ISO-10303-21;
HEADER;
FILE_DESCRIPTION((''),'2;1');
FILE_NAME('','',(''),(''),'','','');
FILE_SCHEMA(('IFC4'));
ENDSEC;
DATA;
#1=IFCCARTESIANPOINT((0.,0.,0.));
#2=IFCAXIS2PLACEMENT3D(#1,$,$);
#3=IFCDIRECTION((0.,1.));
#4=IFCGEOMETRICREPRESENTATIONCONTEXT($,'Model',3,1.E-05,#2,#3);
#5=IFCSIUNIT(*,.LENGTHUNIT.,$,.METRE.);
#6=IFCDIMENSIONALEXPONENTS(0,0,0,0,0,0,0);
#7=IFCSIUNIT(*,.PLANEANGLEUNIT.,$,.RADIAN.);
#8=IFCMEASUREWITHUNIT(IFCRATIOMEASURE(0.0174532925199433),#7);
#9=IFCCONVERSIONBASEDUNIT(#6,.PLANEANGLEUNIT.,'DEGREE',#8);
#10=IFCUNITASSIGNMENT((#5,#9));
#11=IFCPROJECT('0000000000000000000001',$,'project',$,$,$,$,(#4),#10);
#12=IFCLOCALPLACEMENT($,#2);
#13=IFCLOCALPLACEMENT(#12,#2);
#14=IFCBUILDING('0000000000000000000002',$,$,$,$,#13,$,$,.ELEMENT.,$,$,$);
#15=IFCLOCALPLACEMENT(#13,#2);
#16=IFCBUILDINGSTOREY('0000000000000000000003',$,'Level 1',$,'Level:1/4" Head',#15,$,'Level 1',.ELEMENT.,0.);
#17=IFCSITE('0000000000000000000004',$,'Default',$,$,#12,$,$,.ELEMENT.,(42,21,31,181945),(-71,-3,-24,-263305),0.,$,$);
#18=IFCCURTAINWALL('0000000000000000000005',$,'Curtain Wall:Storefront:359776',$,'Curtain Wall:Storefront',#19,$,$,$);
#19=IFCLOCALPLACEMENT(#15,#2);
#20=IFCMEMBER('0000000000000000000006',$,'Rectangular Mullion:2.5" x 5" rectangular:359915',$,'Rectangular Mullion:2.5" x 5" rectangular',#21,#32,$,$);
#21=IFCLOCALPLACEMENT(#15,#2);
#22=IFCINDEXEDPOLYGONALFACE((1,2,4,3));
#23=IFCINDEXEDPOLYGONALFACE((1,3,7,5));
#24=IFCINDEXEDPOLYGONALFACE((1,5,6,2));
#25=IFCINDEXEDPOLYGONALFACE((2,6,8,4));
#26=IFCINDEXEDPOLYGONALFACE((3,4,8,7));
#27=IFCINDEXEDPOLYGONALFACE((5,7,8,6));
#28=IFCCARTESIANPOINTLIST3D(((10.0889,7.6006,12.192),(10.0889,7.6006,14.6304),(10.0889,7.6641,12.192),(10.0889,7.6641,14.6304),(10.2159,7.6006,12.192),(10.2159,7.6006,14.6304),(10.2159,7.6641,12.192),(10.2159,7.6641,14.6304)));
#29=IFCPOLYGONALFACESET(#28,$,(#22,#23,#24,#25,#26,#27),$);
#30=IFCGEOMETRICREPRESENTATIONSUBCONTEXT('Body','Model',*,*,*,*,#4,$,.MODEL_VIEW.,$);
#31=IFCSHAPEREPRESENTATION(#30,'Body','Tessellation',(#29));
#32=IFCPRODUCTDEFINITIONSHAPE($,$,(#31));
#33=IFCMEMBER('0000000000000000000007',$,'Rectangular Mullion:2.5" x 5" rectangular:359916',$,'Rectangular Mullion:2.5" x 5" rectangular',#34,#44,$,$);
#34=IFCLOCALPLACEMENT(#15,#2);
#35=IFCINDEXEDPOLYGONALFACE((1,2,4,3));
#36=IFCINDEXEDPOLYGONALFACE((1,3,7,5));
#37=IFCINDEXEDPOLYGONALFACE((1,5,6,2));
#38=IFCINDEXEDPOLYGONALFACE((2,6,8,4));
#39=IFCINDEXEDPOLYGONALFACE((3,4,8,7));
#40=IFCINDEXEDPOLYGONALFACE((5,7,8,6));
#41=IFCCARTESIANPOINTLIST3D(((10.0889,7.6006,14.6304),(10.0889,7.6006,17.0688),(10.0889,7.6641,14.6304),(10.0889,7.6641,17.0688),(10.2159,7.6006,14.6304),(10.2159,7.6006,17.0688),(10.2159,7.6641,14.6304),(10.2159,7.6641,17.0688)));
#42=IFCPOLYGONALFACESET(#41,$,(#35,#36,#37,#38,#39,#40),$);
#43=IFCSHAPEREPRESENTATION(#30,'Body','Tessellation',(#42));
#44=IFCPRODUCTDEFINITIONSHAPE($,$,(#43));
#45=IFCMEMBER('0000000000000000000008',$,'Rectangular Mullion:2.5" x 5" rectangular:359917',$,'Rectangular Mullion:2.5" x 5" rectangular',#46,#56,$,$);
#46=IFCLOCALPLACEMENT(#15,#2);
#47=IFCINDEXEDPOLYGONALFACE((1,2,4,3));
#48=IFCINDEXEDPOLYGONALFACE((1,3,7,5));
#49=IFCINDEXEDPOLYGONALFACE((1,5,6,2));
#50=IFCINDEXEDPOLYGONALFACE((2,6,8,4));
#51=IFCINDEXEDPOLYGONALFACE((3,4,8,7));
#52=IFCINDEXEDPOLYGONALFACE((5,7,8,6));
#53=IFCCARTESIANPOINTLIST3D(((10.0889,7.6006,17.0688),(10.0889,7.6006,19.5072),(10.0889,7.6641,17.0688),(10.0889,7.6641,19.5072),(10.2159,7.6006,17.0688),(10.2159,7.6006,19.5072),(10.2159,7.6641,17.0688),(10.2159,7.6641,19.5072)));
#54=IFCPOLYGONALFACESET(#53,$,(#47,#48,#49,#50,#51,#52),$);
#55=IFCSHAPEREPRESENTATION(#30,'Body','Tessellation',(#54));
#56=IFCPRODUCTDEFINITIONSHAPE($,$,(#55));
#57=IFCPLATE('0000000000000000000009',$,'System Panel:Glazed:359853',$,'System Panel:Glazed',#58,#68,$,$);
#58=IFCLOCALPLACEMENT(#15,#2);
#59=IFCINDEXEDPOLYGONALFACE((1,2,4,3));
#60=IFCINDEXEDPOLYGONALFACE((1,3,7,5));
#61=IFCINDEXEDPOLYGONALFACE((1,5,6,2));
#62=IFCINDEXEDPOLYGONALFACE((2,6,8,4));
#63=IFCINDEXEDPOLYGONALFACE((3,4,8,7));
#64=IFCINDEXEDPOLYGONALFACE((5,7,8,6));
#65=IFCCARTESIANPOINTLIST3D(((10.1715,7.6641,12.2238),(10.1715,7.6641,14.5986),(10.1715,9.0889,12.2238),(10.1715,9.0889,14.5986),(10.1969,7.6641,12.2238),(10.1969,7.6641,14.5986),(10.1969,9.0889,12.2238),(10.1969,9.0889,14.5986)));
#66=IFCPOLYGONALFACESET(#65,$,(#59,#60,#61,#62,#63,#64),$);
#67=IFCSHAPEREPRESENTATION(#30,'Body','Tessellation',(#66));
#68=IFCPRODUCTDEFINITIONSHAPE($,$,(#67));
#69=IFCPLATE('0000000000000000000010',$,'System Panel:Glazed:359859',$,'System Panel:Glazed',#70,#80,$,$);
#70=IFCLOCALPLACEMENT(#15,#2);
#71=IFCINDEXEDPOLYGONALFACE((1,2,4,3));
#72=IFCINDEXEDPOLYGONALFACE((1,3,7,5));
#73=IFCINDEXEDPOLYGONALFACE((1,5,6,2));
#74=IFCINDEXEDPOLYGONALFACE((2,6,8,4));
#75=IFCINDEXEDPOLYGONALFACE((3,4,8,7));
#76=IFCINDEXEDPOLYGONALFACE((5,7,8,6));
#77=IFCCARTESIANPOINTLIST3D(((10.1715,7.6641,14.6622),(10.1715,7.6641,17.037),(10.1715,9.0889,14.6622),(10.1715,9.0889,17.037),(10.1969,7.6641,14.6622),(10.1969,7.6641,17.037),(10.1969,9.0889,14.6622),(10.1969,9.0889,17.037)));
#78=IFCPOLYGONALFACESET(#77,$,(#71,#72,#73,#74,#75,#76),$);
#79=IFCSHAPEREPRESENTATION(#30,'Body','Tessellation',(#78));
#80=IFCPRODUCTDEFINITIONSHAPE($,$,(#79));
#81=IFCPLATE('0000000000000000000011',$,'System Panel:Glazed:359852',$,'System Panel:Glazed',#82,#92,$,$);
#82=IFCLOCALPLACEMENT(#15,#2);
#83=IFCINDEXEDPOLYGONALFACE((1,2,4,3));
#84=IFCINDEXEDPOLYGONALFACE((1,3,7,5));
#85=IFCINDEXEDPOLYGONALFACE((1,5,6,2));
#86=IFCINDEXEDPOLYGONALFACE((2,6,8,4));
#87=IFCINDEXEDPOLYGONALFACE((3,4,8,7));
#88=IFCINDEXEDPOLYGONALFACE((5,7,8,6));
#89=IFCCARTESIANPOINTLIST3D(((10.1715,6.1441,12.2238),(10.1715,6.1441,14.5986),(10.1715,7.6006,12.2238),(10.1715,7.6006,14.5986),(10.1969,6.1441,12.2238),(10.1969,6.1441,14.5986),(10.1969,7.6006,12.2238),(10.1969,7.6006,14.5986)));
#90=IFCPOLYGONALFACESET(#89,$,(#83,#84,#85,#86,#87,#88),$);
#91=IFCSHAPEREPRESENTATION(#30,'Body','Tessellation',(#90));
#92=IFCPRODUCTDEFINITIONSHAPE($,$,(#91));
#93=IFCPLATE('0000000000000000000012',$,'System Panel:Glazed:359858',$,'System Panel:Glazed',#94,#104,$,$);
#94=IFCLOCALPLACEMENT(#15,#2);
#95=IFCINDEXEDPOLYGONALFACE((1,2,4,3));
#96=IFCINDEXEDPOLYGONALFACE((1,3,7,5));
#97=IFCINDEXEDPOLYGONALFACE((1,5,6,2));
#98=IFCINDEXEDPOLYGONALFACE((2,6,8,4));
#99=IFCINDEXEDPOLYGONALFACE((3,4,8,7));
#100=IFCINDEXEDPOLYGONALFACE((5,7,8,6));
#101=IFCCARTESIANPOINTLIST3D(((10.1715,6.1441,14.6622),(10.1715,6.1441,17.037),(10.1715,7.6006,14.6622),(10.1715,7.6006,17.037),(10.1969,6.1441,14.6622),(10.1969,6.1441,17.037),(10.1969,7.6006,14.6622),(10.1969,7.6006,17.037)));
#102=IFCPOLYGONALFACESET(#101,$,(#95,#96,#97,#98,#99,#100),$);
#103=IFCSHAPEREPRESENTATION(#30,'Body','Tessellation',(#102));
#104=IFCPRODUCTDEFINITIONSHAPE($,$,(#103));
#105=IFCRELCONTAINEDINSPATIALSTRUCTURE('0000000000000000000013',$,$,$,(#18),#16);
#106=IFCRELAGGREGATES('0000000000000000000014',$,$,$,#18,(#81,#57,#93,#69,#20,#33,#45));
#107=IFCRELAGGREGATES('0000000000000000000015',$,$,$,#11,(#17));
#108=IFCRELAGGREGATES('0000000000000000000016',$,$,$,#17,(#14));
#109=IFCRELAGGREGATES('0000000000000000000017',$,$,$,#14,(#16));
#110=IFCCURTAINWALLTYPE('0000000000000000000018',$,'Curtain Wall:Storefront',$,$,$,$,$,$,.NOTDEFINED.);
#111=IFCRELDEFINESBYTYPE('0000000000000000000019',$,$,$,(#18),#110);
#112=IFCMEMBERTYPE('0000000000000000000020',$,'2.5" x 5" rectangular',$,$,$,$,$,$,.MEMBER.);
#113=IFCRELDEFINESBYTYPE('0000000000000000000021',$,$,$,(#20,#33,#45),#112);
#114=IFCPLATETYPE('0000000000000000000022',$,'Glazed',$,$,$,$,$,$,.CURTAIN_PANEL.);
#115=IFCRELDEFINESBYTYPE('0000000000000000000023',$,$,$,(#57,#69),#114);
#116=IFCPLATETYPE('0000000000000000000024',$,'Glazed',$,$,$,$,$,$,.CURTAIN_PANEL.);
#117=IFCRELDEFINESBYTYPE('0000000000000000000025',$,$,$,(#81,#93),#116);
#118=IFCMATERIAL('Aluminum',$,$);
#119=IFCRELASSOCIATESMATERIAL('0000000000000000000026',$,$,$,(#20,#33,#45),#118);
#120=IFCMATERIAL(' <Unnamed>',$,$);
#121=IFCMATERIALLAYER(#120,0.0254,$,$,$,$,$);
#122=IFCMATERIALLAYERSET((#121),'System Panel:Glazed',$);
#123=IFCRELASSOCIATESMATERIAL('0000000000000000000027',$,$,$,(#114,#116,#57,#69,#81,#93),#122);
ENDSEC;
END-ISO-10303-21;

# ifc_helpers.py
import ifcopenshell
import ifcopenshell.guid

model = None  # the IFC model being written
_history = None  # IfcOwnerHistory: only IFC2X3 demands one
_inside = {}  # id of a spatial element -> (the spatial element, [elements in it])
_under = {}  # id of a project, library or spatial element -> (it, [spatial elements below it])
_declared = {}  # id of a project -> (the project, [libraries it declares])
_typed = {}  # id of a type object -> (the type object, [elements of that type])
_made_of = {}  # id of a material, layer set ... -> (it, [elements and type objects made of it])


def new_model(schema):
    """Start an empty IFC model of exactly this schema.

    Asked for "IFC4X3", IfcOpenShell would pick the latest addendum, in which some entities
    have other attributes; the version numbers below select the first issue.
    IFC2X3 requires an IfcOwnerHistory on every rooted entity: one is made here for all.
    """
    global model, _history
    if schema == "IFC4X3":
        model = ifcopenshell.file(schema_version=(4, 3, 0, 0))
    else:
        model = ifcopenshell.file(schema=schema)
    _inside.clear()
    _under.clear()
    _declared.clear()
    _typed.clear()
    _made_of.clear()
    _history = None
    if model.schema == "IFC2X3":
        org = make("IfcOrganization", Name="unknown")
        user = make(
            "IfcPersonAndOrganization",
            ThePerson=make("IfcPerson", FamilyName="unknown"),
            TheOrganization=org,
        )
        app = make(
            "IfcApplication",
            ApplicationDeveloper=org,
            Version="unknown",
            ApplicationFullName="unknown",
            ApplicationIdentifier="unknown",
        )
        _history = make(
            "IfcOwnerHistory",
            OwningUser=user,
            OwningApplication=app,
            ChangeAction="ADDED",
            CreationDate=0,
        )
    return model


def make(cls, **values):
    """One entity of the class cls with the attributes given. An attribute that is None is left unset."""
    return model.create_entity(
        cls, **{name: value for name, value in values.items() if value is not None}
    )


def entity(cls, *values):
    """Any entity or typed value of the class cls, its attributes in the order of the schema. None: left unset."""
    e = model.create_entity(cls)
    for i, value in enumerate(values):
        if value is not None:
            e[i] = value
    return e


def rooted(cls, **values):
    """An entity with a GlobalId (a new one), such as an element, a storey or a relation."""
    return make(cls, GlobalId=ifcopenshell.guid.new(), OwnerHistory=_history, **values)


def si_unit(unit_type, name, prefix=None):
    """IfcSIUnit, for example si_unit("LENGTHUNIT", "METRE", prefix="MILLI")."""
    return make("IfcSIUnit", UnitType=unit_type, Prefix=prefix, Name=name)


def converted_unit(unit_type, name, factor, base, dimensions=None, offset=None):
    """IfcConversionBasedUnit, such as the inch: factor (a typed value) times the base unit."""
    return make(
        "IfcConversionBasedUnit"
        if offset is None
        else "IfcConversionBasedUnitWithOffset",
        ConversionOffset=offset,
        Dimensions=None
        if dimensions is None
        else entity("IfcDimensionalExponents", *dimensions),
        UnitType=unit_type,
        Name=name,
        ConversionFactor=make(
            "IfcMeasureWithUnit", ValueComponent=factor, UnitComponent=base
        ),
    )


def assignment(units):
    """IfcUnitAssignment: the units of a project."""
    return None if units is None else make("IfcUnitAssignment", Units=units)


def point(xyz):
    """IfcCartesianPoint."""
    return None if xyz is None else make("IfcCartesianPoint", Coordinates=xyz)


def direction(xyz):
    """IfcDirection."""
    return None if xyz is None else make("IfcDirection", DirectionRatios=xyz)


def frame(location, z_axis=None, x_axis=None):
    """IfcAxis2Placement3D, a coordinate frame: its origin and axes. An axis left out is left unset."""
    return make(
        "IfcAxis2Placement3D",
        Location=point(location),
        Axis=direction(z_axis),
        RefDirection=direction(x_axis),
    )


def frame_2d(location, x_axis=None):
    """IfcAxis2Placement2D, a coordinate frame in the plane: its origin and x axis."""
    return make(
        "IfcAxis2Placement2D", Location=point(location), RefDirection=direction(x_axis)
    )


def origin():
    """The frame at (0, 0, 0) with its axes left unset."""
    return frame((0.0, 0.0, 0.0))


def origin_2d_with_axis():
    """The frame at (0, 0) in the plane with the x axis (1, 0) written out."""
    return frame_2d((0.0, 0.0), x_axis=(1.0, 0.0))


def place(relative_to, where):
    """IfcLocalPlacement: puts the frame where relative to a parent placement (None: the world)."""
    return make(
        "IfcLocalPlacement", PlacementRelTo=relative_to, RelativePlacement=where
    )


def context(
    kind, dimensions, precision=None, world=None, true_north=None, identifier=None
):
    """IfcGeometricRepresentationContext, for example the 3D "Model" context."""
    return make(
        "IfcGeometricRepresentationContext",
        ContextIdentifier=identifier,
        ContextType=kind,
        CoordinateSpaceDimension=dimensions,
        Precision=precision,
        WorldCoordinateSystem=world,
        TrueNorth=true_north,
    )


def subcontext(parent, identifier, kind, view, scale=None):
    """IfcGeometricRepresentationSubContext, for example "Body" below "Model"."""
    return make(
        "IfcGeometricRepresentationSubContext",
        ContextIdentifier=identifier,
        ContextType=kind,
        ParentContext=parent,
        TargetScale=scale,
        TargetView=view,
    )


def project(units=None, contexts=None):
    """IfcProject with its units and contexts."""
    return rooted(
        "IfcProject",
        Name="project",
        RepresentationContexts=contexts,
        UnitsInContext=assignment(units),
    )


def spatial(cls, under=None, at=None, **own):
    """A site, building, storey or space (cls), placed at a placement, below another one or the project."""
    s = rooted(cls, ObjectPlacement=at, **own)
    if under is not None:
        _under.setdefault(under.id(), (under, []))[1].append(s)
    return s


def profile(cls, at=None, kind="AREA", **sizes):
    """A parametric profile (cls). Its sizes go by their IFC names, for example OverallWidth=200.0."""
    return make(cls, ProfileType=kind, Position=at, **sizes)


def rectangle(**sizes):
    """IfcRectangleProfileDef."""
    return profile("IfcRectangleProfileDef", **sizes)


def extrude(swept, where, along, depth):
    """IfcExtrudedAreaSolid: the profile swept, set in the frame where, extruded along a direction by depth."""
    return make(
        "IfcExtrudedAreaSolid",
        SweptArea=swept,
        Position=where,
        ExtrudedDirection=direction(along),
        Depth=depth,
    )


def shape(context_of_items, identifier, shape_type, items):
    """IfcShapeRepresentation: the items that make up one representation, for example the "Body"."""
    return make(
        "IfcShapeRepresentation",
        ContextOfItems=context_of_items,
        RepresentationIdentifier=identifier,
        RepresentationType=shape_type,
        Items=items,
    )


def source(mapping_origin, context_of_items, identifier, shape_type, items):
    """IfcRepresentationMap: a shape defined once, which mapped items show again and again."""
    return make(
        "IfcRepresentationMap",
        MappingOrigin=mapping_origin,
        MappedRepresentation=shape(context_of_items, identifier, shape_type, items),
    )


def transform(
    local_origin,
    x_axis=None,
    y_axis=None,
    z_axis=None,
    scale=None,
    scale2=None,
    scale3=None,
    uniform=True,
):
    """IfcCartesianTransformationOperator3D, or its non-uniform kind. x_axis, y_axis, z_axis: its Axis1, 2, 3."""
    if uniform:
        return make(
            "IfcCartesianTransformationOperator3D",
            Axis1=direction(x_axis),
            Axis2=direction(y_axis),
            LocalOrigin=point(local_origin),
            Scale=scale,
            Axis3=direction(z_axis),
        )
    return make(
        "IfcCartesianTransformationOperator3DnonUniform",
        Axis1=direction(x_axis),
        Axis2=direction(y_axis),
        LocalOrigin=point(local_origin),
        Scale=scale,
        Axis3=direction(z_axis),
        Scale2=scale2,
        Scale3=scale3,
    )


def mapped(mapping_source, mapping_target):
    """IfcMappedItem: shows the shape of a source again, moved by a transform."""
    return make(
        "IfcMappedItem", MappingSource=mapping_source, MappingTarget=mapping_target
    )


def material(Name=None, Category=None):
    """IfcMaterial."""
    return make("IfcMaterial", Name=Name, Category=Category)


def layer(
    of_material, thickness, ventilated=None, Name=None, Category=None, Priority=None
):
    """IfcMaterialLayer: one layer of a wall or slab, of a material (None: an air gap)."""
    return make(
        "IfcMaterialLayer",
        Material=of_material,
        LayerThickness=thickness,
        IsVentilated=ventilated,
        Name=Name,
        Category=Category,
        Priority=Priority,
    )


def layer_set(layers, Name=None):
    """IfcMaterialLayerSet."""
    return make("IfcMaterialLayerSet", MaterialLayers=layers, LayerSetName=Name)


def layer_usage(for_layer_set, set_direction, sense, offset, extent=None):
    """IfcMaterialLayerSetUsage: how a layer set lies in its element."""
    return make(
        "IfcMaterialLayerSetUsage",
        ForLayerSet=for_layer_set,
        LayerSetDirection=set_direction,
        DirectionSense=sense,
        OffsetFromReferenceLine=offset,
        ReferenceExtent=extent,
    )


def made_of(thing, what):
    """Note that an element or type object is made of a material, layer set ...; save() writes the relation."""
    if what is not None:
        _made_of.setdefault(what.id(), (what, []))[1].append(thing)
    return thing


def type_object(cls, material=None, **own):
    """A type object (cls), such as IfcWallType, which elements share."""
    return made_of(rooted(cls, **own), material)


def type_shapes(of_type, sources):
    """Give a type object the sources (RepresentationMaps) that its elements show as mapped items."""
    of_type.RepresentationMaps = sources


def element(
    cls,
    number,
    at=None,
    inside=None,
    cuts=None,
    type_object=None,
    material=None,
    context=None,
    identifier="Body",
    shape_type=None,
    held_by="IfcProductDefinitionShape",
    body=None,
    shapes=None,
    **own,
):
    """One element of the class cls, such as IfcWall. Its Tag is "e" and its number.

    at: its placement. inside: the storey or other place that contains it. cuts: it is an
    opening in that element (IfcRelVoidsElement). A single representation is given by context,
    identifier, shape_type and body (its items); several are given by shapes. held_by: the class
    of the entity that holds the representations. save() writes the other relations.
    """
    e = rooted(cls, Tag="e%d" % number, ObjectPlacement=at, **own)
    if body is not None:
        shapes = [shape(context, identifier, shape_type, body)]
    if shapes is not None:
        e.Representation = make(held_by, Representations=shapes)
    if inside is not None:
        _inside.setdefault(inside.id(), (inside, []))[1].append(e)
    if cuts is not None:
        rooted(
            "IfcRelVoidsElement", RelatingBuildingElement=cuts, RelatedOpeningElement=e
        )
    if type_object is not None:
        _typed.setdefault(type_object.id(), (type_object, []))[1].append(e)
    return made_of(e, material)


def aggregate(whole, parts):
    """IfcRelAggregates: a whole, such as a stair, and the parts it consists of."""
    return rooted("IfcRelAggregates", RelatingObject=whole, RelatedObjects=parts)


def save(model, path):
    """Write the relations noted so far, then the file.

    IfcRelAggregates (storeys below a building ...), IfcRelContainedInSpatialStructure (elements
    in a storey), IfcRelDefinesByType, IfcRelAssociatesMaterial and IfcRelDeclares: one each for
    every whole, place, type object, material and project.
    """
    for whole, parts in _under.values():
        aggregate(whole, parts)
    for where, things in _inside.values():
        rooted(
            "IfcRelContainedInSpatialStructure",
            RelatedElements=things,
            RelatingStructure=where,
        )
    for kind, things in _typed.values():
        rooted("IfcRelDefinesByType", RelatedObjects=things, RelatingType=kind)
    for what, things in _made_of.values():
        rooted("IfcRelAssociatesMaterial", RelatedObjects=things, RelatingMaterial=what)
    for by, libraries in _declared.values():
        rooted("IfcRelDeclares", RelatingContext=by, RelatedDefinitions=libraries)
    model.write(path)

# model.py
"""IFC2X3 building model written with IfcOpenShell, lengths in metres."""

from ifc_helpers import new_model, entity, si_unit, converted_unit, direction, frame, frame_2d, origin, origin_2d_with_axis, place, context, subcontext, project, spatial, rectangle, extrude, source, transform, mapped, material, layer, layer_set, layer_usage, type_object, type_shapes, element, aggregate, save


model = new_model("IFC2X3")

# Units and contexts
model_context = context("Model", 3, precision=1e-05, world=origin(), true_north=direction((0.0, 1.0)))
body_context = subcontext(model_context, "Body", "Model", "MODEL_VIEW")
ifc_project = project(units=[si_unit("LENGTHUNIT", "METRE"), converted_unit("PLANEANGLEUNIT", "DEGREE", entity("IfcRatioMeasure", 0.0174532925199433), si_unit("PLANEANGLEUNIT", "RADIAN"), dimensions=[0, 0, 0, 0, 0, 0, 0])], contexts=[model_context])

# Site, building, storey
site_placement = place(None, origin())
site = spatial("IfcSite", under=ifc_project, at=site_placement, Name="Default", CompositionType="ELEMENT", RefLatitude=(42, 21, 31, 181945), RefLongitude=(-71, -3, -24, -263305), RefElevation=0.0)
building_placement = place(site_placement, origin())
building = spatial("IfcBuilding", under=site, at=building_placement, CompositionType="ELEMENT")
storey_placement = place(building_placement, origin())
storey = spatial("IfcBuildingStorey", under=building, at=storey_placement, Name="Level 1", ObjectType="Level:1/4\" Head", LongName="Level 1", CompositionType="ELEMENT", Elevation=0.0)

# Curtain wall, members, plates
curtain_wall_type = type_object("IfcCurtainWallType", Name="Curtain Wall:Storefront", PredefinedType="NOTDEFINED")
curtain_wall_placement = place(storey_placement, origin())
curtain_wall = element("IfcCurtainWall", 1, at=curtain_wall_placement, inside=storey, type_object=curtain_wall_type, Name="Curtain Wall:Storefront:359776", ObjectType="Curtain Wall:Storefront")
ifc_material_1 = material(Name="Aluminum")
member_type_1 = type_object("IfcMemberType", Name="2.5\" x 5\" rectangular", PredefinedType="MEMBER")
shared_shape_1 = source(origin(), body_context, "Body", "SweptSolid", [
    extrude(rectangle(XDim=0.127, YDim=0.0635, at=origin_2d_with_axis()), frame((0.0, 0.0, -2.4384), z_axis=(0.0, 0.0, 1.0), x_axis=(0.0, -1.0, 0.0)), (0.0, 0.0, 1.0), 2.4384),
])
type_shapes(member_type_1, [shared_shape_1])
member_1_placement = place(storey_placement, frame((10.1524, 7.6324, 12.192), z_axis=(0.0, 0.0, -1.0), x_axis=(0.0, 1.0, 0.0)))
member_1 = element("IfcMember", 2, at=member_1_placement, type_object=member_type_1, material=ifc_material_1, Name="Rectangular Mullion:2.5\" x 5\" rectangular:359915", ObjectType="Rectangular Mullion:2.5\" x 5\" rectangular", context=body_context, shape_type="MappedRepresentation", body=[
    mapped(shared_shape_1, transform((0.0, 0.0, 0.0), scale=1.0)),
])
member_2_placement = place(storey_placement, frame((10.1524, 7.6324, 14.6304), z_axis=(0.0, 0.0, -1.0), x_axis=(0.0, 1.0, 0.0)))
member_2 = element("IfcMember", 3, at=member_2_placement, type_object=member_type_1, material=ifc_material_1, Name="Rectangular Mullion:2.5\" x 5\" rectangular:359916", ObjectType="Rectangular Mullion:2.5\" x 5\" rectangular", context=body_context, shape_type="MappedRepresentation", body=[
    mapped(shared_shape_1, transform((0.0, 0.0, 0.0), scale=1.0)),
])
member_3_placement = place(storey_placement, frame((10.1524, 7.6324, 17.0688), z_axis=(0.0, 0.0, -1.0), x_axis=(0.0, 1.0, 0.0)))
member_3 = element("IfcMember", 4, at=member_3_placement, type_object=member_type_1, material=ifc_material_1, Name="Rectangular Mullion:2.5\" x 5\" rectangular:359917", ObjectType="Rectangular Mullion:2.5\" x 5\" rectangular", context=body_context, shape_type="MappedRepresentation", body=[
    mapped(shared_shape_1, transform((0.0, 0.0, 0.0), scale=1.0)),
])
ifc_material_2 = material(Name=" <Unnamed>")
ifc_layer = layer(ifc_material_2, 0.0254)
ifc_layer_set = layer_set([ifc_layer], Name="System Panel:Glazed")
ifc_layer_usage_1 = layer_usage(ifc_layer_set, "AXIS3", "POSITIVE", 0.1042)
plate_type_1 = type_object("IfcPlateType", Name="Glazed", PredefinedType="CURTAIN_PANEL", material=ifc_layer_set)
shared_shape_2 = source(origin(), body_context, "Body", "SweptSolid", [
    extrude(rectangle(XDim=0.0254, YDim=1.4248, at=frame_2d((0.0, 0.0), x_axis=(1.0, 0.0))), frame((0.7124, 0.0127, 0.0), z_axis=(0.0, 0.0, 1.0), x_axis=(0.0, 1.0, 0.0)), (0.0, 0.0, 1.0), 2.3749),
])
type_shapes(plate_type_1, [shared_shape_2])
plate_1_placement = place(curtain_wall_placement, frame((10.1969, 7.6641, 12.2238), z_axis=(0.0, 0.0, 1.0), x_axis=(0.0, 1.0, 0.0)))
plate_1 = element("IfcPlate", 5, at=plate_1_placement, type_object=plate_type_1, material=ifc_layer_usage_1, Name="System Panel:Glazed:359853", ObjectType="System Panel:Glazed", context=body_context, shape_type="MappedRepresentation", body=[
    mapped(shared_shape_2, transform((0.0, 0.0, 0.0), scale=1.0)),
])
ifc_layer_usage_2 = layer_usage(ifc_layer_set, "AXIS3", "POSITIVE", 0.1042)
plate_2_placement = place(curtain_wall_placement, frame((10.1969, 7.6641, 14.6622), z_axis=(0.0, 0.0, 1.0), x_axis=(0.0, 1.0, 0.0)))
plate_2 = element("IfcPlate", 6, at=plate_2_placement, type_object=plate_type_1, material=ifc_layer_usage_2, Name="System Panel:Glazed:359859", ObjectType="System Panel:Glazed", context=body_context, shape_type="MappedRepresentation", body=[
    mapped(shared_shape_2, transform((0.0, 0.0, 0.0), scale=1.0)),
])
ifc_layer_usage_3 = layer_usage(ifc_layer_set, "AXIS3", "POSITIVE", 0.1042)
plate_type_2 = type_object("IfcPlateType", Name="Glazed", PredefinedType="CURTAIN_PANEL", material=ifc_layer_set)
shared_shape_3 = source(origin(), body_context, "Body", "SweptSolid", [
    extrude(rectangle(XDim=0.0254, YDim=1.4565, at=origin_2d_with_axis()), frame((0.7282, 0.0127, 0.0), z_axis=(0.0, 0.0, 1.0), x_axis=(0.0, 1.0, 0.0)), (0.0, 0.0, 1.0), 2.3749),
])
type_shapes(plate_type_2, [shared_shape_3])
plate_3_placement = place(curtain_wall_placement, frame((10.1969, 6.1441, 12.2238), z_axis=(0.0, 0.0, 1.0), x_axis=(0.0, 1.0, 0.0)))
plate_3 = element("IfcPlate", 7, at=plate_3_placement, type_object=plate_type_2, material=ifc_layer_usage_3, Name="System Panel:Glazed:359852", ObjectType="System Panel:Glazed", context=body_context, shape_type="MappedRepresentation", body=[
    mapped(shared_shape_3, transform((0.0, 0.0, 0.0), scale=1.0)),
])
ifc_layer_usage_4 = layer_usage(ifc_layer_set, "AXIS3", "POSITIVE", 0.1042)
plate_4_placement = place(curtain_wall_placement, frame((10.1969, 6.1441, 14.6622), z_axis=(0.0, 0.0, 1.0), x_axis=(0.0, 1.0, 0.0)))
plate_4 = element("IfcPlate", 8, at=plate_4_placement, type_object=plate_type_2, material=ifc_layer_usage_4, Name="System Panel:Glazed:359858", ObjectType="System Panel:Glazed", context=body_context, shape_type="MappedRepresentation", body=[
    mapped(shared_shape_3, transform((0.0, 0.0, 0.0), scale=1.0)),
])
aggregate(curtain_wall, [plate_3, plate_1, plate_4, plate_2, member_1, member_2, member_3])

save(model, "model.ifc")
